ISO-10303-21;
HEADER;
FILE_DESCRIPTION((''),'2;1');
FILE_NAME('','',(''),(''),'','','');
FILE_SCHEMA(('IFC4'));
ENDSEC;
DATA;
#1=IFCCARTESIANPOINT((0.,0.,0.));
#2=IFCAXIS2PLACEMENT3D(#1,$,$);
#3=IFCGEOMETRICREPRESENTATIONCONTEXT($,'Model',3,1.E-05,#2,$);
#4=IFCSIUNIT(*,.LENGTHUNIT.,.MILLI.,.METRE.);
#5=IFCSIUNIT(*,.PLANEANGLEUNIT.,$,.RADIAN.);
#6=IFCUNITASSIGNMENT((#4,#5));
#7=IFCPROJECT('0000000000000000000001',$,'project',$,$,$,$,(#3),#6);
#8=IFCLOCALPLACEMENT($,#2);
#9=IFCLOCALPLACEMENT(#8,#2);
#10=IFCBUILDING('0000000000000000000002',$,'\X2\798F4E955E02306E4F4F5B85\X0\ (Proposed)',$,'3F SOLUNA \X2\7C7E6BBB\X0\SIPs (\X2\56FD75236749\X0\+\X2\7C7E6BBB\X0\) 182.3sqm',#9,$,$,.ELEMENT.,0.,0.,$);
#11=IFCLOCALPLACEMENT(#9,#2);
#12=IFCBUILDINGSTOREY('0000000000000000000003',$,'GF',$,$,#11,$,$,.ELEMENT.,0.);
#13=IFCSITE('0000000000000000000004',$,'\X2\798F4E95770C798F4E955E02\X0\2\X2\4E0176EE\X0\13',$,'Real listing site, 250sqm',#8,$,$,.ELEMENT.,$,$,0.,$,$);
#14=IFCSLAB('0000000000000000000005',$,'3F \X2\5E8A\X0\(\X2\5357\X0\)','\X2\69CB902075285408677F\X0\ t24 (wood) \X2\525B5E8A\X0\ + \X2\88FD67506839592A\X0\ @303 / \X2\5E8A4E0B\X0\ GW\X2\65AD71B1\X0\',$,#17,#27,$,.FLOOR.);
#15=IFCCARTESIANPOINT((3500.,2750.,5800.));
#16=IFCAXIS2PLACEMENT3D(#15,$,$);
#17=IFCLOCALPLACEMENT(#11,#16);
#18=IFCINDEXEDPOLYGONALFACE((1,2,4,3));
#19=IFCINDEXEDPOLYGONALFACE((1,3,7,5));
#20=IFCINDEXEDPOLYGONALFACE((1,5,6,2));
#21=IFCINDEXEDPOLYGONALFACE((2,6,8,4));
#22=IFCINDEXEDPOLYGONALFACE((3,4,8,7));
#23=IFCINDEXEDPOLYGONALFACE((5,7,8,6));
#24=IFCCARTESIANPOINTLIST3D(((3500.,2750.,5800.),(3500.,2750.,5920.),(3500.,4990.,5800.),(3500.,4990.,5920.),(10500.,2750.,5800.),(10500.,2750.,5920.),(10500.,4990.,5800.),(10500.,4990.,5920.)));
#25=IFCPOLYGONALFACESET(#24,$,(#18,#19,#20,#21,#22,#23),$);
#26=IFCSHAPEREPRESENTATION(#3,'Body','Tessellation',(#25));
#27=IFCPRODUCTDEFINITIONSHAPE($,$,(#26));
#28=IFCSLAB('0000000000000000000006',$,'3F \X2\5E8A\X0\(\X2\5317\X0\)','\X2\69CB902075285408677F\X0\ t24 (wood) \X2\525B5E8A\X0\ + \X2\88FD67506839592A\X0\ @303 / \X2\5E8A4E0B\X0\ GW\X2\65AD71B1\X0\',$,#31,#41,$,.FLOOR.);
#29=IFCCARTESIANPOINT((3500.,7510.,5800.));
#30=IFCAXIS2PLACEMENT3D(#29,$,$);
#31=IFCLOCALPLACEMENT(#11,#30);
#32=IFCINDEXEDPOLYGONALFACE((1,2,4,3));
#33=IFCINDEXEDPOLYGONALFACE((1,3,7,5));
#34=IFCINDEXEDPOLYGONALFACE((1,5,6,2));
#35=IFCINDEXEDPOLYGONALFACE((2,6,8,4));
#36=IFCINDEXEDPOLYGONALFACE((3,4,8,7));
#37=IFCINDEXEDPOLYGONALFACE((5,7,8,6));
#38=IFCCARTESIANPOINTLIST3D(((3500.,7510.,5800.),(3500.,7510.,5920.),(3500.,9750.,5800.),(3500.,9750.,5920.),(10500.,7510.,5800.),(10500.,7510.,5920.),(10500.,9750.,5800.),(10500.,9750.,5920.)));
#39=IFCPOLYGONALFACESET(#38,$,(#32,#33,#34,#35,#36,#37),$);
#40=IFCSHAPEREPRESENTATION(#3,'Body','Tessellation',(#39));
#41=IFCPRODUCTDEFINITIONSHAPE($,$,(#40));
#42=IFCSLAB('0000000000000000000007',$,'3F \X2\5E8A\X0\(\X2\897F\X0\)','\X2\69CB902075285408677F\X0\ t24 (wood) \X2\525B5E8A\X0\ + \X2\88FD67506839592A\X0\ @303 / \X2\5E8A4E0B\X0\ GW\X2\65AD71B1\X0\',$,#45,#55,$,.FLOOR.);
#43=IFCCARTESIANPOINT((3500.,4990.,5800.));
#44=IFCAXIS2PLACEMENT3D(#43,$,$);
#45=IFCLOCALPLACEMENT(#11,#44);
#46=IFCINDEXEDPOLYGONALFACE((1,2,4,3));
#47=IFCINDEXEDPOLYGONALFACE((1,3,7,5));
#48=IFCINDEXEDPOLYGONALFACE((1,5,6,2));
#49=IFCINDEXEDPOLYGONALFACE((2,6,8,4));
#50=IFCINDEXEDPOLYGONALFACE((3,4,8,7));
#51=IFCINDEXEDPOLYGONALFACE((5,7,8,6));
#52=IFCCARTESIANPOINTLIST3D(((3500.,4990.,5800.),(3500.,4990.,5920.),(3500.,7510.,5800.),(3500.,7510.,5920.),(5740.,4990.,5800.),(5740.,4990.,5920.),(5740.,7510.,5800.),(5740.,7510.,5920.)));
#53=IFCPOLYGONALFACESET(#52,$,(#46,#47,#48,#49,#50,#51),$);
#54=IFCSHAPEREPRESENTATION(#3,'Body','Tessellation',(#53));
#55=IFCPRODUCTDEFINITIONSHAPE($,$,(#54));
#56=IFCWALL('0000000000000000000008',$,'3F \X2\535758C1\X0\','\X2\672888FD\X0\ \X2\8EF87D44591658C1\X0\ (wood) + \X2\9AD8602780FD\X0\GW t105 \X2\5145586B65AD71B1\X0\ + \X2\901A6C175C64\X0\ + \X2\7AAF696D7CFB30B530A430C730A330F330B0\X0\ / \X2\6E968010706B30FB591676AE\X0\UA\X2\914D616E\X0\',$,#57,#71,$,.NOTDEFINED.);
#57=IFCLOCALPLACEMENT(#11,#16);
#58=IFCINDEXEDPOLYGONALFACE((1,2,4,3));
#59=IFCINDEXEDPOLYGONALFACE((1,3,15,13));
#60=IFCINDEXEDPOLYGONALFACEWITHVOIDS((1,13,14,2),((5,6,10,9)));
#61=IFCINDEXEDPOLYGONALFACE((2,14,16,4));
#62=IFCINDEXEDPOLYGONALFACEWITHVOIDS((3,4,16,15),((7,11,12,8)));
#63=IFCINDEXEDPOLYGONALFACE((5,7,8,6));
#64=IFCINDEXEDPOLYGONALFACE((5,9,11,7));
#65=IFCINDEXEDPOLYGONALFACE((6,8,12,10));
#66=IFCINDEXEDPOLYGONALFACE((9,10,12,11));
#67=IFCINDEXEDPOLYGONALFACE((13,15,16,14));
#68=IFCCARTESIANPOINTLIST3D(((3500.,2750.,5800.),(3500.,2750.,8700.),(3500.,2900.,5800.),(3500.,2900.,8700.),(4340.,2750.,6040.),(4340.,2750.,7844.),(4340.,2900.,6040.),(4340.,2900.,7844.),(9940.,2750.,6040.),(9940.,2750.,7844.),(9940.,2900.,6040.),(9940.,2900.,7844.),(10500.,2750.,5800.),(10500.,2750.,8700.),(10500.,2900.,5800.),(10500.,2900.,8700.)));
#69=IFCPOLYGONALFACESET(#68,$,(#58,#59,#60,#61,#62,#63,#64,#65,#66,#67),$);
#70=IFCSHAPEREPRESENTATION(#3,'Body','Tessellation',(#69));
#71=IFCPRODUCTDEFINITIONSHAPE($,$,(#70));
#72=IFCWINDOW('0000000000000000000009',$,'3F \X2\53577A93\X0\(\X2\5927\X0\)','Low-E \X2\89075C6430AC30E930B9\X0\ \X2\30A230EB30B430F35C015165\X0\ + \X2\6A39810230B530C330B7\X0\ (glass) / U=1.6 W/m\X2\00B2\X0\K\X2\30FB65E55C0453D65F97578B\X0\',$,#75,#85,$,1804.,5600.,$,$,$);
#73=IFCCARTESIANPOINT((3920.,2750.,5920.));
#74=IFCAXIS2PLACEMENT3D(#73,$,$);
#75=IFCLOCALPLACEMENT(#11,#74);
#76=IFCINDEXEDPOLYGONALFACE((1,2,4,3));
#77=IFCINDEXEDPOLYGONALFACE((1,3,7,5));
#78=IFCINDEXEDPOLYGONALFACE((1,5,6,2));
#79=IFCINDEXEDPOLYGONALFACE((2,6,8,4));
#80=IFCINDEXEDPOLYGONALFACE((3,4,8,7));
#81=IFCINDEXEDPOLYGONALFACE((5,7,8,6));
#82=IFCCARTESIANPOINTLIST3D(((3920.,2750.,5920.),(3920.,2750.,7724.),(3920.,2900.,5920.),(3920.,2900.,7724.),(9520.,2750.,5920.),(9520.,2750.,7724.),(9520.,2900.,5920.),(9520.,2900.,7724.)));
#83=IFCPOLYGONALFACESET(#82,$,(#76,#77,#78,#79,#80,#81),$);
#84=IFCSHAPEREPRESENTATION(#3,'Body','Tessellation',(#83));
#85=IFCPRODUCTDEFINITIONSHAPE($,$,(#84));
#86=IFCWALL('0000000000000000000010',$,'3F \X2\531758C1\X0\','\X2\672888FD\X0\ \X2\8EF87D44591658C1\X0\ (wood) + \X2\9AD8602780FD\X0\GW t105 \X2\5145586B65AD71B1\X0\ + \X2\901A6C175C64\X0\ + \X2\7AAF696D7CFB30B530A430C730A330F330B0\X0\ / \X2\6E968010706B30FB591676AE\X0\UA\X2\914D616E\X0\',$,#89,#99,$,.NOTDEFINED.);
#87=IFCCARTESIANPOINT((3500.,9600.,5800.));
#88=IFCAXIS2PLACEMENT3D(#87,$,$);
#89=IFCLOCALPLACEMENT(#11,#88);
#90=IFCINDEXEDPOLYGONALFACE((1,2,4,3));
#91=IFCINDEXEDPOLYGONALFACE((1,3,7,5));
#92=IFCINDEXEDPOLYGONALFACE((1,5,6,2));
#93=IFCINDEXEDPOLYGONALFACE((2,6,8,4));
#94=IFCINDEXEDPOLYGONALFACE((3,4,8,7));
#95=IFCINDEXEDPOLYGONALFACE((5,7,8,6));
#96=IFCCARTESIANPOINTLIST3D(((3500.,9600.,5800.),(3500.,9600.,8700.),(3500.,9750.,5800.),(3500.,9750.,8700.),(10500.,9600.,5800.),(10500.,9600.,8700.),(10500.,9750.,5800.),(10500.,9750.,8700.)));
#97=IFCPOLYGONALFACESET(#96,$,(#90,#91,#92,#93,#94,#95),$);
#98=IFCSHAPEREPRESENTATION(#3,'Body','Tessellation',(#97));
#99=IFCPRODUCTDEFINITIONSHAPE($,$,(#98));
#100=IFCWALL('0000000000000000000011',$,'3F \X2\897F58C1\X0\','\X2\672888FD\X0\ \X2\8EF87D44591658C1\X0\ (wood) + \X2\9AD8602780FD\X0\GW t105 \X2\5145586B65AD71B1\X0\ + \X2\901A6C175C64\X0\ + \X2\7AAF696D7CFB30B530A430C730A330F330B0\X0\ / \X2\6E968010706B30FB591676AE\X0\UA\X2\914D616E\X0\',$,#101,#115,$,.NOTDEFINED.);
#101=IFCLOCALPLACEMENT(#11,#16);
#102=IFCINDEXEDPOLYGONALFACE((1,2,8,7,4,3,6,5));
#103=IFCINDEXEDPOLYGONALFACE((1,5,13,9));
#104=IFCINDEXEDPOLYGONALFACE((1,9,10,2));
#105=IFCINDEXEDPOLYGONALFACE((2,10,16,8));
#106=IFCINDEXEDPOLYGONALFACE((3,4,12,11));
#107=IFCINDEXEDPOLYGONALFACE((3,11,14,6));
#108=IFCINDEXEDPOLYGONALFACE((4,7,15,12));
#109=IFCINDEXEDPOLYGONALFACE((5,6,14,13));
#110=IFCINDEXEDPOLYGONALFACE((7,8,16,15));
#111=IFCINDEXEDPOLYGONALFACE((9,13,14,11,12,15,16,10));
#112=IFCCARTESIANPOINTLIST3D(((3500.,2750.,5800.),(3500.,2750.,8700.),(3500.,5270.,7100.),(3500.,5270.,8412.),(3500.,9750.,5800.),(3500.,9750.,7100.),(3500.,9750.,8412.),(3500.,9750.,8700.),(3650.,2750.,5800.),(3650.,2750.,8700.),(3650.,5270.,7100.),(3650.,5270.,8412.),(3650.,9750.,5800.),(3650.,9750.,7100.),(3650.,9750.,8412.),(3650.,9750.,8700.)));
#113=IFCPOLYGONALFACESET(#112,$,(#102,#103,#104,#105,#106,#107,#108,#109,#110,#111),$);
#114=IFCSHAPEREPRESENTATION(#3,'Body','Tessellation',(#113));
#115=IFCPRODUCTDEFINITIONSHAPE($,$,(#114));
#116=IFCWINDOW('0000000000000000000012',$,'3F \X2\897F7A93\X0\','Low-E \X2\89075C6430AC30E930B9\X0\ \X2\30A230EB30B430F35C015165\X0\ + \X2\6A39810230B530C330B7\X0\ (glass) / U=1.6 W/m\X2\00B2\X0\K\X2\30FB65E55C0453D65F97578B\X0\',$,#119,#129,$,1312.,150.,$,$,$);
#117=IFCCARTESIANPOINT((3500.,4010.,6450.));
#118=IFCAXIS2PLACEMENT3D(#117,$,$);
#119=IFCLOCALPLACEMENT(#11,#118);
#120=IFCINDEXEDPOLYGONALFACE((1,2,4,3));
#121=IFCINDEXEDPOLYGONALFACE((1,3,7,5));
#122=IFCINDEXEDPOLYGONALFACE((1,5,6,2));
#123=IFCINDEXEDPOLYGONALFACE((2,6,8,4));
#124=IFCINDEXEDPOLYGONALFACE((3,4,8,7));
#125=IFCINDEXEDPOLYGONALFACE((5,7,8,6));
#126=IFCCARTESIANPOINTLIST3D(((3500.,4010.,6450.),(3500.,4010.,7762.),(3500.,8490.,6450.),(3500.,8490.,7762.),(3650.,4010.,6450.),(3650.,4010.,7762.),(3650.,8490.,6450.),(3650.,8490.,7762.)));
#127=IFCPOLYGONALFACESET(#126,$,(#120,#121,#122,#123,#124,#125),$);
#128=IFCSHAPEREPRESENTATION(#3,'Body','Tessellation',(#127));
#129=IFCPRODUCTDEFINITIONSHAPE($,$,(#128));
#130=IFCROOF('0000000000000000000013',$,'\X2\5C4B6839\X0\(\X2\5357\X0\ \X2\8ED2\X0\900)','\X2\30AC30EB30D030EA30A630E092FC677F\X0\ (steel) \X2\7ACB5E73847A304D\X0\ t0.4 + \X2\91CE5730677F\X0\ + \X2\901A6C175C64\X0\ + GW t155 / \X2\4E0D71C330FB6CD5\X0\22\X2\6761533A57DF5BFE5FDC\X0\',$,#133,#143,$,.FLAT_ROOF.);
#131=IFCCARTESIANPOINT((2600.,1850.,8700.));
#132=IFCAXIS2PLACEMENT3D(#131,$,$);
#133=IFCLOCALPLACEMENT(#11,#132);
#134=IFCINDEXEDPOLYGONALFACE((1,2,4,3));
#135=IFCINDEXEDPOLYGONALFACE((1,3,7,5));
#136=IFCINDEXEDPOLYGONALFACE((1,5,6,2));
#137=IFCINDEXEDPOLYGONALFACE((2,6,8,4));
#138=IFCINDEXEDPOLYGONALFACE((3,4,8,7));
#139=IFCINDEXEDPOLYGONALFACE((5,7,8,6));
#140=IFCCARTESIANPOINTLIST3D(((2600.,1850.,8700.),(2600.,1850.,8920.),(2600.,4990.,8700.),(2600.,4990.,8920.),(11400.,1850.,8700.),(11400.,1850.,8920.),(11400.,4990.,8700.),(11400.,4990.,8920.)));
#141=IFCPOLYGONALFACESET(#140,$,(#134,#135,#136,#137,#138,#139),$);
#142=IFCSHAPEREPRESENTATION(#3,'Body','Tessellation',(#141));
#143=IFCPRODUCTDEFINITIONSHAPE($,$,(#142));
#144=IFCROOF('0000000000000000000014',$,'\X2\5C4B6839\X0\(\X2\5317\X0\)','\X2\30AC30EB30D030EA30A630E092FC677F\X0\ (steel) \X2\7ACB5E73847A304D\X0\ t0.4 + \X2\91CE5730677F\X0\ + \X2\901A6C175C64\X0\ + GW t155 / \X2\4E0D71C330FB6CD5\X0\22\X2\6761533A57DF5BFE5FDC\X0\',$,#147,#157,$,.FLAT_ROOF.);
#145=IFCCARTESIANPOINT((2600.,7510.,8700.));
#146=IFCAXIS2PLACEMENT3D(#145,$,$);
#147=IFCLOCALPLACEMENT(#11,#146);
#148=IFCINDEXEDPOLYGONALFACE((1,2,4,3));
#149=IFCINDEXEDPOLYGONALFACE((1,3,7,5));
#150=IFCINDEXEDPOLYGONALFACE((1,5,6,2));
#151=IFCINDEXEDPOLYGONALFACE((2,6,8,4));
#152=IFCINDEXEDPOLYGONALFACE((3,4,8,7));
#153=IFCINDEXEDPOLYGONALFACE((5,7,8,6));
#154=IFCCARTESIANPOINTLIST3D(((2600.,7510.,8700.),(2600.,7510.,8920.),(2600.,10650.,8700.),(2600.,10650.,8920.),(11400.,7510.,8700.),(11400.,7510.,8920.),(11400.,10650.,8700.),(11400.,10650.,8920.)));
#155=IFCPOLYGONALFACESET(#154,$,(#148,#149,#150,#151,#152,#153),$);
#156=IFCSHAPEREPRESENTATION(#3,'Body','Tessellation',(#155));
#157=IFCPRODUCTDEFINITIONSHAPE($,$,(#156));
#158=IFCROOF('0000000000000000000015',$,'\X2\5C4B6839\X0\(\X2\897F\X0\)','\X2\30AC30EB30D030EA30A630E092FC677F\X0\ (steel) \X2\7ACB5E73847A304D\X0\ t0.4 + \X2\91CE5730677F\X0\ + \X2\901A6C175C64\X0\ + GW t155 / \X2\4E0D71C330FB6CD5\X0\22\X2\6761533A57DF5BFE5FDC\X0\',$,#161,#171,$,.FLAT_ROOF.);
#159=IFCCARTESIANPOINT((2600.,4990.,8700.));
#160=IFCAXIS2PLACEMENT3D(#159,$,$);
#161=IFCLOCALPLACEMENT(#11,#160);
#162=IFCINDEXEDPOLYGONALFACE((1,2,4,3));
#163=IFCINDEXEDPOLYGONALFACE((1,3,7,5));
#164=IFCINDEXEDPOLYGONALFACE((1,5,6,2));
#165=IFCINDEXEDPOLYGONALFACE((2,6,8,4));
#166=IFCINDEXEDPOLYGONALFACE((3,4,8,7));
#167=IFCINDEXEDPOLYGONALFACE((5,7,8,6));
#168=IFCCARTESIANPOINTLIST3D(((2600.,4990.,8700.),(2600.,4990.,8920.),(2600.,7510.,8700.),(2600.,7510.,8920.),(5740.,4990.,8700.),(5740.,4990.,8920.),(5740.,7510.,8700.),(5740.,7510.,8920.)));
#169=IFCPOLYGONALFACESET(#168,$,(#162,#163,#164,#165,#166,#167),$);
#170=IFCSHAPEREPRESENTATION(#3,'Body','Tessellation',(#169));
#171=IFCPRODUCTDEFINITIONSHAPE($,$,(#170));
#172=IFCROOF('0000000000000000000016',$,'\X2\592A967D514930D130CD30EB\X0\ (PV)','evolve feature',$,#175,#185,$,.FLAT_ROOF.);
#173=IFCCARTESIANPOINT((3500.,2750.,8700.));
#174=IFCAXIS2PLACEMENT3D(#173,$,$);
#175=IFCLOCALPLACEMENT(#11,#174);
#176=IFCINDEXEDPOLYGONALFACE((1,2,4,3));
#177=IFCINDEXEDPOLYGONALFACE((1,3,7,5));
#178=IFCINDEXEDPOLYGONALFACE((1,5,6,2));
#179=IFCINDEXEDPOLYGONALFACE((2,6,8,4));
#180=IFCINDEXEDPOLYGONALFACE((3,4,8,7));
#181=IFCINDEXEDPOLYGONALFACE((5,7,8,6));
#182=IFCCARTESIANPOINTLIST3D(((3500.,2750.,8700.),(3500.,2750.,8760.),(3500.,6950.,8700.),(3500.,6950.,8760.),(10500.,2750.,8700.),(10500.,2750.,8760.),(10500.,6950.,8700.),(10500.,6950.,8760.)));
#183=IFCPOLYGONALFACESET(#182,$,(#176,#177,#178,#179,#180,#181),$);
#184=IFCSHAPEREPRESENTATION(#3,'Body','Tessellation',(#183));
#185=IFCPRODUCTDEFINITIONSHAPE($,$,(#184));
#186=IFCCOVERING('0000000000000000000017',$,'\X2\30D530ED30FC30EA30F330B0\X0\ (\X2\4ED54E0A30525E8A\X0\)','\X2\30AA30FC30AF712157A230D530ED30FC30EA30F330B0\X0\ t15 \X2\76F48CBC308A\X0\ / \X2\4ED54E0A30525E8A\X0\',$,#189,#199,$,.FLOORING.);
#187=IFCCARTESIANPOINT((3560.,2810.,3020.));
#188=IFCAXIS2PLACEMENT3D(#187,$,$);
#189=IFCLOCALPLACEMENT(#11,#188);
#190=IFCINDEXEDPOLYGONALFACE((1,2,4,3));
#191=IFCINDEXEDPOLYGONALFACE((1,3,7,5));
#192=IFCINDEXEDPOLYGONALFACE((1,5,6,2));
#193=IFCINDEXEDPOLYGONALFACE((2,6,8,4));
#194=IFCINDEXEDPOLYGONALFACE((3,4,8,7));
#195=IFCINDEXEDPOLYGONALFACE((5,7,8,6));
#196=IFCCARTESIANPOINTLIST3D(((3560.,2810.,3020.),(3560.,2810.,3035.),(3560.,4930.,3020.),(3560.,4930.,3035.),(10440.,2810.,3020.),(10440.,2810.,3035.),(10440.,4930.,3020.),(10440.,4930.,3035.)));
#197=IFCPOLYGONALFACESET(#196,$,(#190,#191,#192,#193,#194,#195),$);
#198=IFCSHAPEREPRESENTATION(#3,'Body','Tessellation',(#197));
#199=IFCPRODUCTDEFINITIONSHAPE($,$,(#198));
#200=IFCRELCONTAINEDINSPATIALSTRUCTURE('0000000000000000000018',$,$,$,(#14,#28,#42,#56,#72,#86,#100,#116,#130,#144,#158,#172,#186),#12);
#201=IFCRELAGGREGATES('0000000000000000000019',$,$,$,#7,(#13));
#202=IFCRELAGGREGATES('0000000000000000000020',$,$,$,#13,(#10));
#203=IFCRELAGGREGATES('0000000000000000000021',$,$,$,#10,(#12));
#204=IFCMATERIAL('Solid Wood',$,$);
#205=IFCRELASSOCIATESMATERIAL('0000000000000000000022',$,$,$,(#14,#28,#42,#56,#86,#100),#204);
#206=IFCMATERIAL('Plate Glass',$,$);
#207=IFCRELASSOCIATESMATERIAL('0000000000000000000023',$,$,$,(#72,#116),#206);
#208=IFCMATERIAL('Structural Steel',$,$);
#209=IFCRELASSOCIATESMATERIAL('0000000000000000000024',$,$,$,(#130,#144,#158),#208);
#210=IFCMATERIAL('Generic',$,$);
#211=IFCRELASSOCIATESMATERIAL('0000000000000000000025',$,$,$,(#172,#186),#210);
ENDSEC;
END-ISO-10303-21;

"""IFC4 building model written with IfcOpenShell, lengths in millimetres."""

from ifc_helpers import new_model, si_unit, frame, frame_2d, origin, place, context, project, spatial, rectangle, extrude, material, element, fill, save


model = new_model("IFC4")

# Units and contexts
model_context = context("Model", 3, precision=1e-05, world=origin())
ifc_project = project(units=[si_unit("LENGTHUNIT", "METRE", prefix="MILLI"), si_unit("PLANEANGLEUNIT", "RADIAN")], contexts=[model_context])

# Site, building, storey
site_placement = place(None, origin())
site = spatial("IfcSite", under=ifc_project, at=site_placement, Name="福井県福井市2丁目13", ObjectType="Real listing site, 250sqm", CompositionType="ELEMENT", RefElevation=0.0)
building_placement = place(site_placement, origin())
building = spatial("IfcBuilding", under=site, at=building_placement, Name="福井市の住宅 (Proposed)", ObjectType="3F SOLUNA 籾殻SIPs (国産杉+籾殻) 182.3sqm", CompositionType="ELEMENT", ElevationOfRefHeight=0.0, ElevationOfTerrain=0.0)
storey_placement = place(building_placement, origin())
storey = spatial("IfcBuildingStorey", under=building, at=storey_placement, Name="GF", CompositionType="ELEMENT", Elevation=0.0)

# Slabs
ifc_material_1 = material(Name="Solid Wood")
slab_1_placement = place(storey_placement, frame((3500.0, 2750.0, 5800.0)))
element("IfcSlab", 1, at=slab_1_placement, inside=storey, material=ifc_material_1, Name="3F 床(南)", Description="構造用合板 t24 (wood) 剛床 + 製材根太 @303 / 床下 GW断熱", PredefinedType="FLOOR", context=model_context, shape_type="SweptSolid", body=[
    extrude(rectangle(XDim=7000.0, YDim=2240.0, at=frame_2d((3500.0, 1120.0))), frame((3500.0, 2750.0, 5800.0)), (0.0, 0.0, 1.0), 120.0),
])
slab_2_placement = place(storey_placement, frame((3500.0, 7510.0, 5800.0)))
element("IfcSlab", 2, at=slab_2_placement, inside=storey, material=ifc_material_1, Name="3F 床(北)", Description="構造用合板 t24 (wood) 剛床 + 製材根太 @303 / 床下 GW断熱", PredefinedType="FLOOR", context=model_context, shape_type="SweptSolid", body=[
    extrude(rectangle(XDim=7000.0, YDim=2240.0, at=frame_2d((3500.0, 1120.0))), frame((3500.0, 7510.0, 5800.0)), (0.0, 0.0, 1.0), 120.0),
])
slab_3_placement = place(storey_placement, frame((3500.0, 4990.0, 5800.0)))
element("IfcSlab", 3, at=slab_3_placement, inside=storey, material=ifc_material_1, Name="3F 床(西)", Description="構造用合板 t24 (wood) 剛床 + 製材根太 @303 / 床下 GW断熱", PredefinedType="FLOOR", context=model_context, shape_type="SweptSolid", body=[
    extrude(rectangle(XDim=2240.0, YDim=2520.0, at=frame_2d((1120.0, 1260.0))), frame((3500.0, 4990.0, 5800.0)), (0.0, 0.0, 1.0), 120.0),
])

# Wall, opening, window
wall_1_placement = place(storey_placement, frame((3500.0, 2750.0, 5800.0)))
wall_1 = element("IfcWall", 4, at=wall_1_placement, inside=storey, material=ifc_material_1, Name="3F 南壁", Description="木製 軸組外壁 (wood) + 高性能GW t105 充填断熱 + 通気層 + 窯業系サイディング / 準耐火・外皮UA配慮", PredefinedType="NOTDEFINED", context=model_context, shape_type="SweptSolid", body=[
    extrude(rectangle(XDim=7000.0, YDim=150.0, at=frame_2d((3500.0, 75.0))), frame((3500.0, 2750.0, 5800.0)), (0.0, 0.0, 1.0), 2900.0),
])
opening_1_placement = place(storey_placement, frame((3920.0, 2750.0, 5920.0)))
opening_1 = element("IfcOpeningElement", 5, at=opening_1_placement, cuts=wall_1, PredefinedType="NOTDEFINED", context=model_context, shape_type="SweptSolid", body=[
    extrude(rectangle(XDim=5600.0, YDim=150.0, at=frame_2d((2800.0, 75.0))), frame((3920.0, 2750.0, 5920.0)), (0.0, 0.0, 1.0), 1804.0),
])
ifc_material_2 = material(Name="Plate Glass")
window_1_placement = place(storey_placement, frame((3920.0, 2750.0, 5920.0)))
window_1 = element("IfcWindow", 6, at=window_1_placement, inside=storey, material=ifc_material_2, Name="3F 南窓(大)", Description="Low-E 複層ガラス アルゴン封入 + 樹脂サッシ (glass) / U=1.6 W/m²K・日射取得型", OverallHeight=1804.0, OverallWidth=5600.0, context=model_context, shape_type="SweptSolid", body=[
    extrude(rectangle(XDim=5600.0, YDim=150.0, at=frame_2d((2800.0, 75.0))), frame((3920.0, 2750.0, 5920.0)), (0.0, 0.0, 1.0), 1804.0),
])
fill(opening_1, window_1)

# Wall
wall_2_placement = place(storey_placement, frame((3500.0, 9600.0, 5800.0)))
element("IfcWall", 7, at=wall_2_placement, inside=storey, material=ifc_material_1, Name="3F 北壁", Description="木製 軸組外壁 (wood) + 高性能GW t105 充填断熱 + 通気層 + 窯業系サイディング / 準耐火・外皮UA配慮", PredefinedType="NOTDEFINED", context=model_context, shape_type="SweptSolid", body=[
    extrude(rectangle(XDim=7000.0, YDim=150.0, at=frame_2d((3500.0, 75.0))), frame((3500.0, 9600.0, 5800.0)), (0.0, 0.0, 1.0), 2900.0),
])

# Wall, opening, window
wall_3_placement = place(storey_placement, frame((3500.0, 2750.0, 5800.0)))
wall_3 = element("IfcWall", 8, at=wall_3_placement, inside=storey, material=ifc_material_1, Name="3F 西壁", Description="木製 軸組外壁 (wood) + 高性能GW t105 充填断熱 + 通気層 + 窯業系サイディング / 準耐火・外皮UA配慮", PredefinedType="NOTDEFINED", context=model_context, shape_type="SweptSolid", body=[
    extrude(rectangle(XDim=150.0, YDim=7000.0, at=frame_2d((75.0, 3500.0))), frame((3500.0, 2750.0, 5800.0)), (0.0, 0.0, 1.0), 2900.0),
])
opening_2_placement = place(storey_placement, frame((3500.0, 4010.0, 6450.0)))
opening_2 = element("IfcOpeningElement", 9, at=opening_2_placement, cuts=wall_3, PredefinedType="NOTDEFINED", context=model_context, shape_type="SweptSolid", body=[
    extrude(rectangle(XDim=150.0, YDim=4480.0, at=frame_2d((75.0, 2240.0))), frame((3500.0, 4010.0, 6450.0)), (0.0, 0.0, 1.0), 1312.0),
])
window_2_placement = place(storey_placement, frame((3500.0, 4010.0, 6450.0)))
window_2 = element("IfcWindow", 10, at=window_2_placement, inside=storey, material=ifc_material_2, Name="3F 西窓", Description="Low-E 複層ガラス アルゴン封入 + 樹脂サッシ (glass) / U=1.6 W/m²K・日射取得型", OverallHeight=1312.0, OverallWidth=150.0, context=model_context, shape_type="SweptSolid", body=[
    extrude(rectangle(XDim=150.0, YDim=4480.0, at=frame_2d((75.0, 2240.0))), frame((3500.0, 4010.0, 6450.0)), (0.0, 0.0, 1.0), 1312.0),
])
fill(opening_2, window_2)

# Roofs
ifc_material_3 = material(Name="Structural Steel")
roof_1_placement = place(storey_placement, frame((2600.0, 1850.0, 8700.0)))
element("IfcRoof", 11, at=roof_1_placement, inside=storey, material=ifc_material_3, Name="屋根(南 軒900)", Description="ガルバリウム鋼板 (steel) 立平葺き t0.4 + 野地板 + 通気層 + GW t155 / 不燃・法22条区域対応", PredefinedType="FLAT_ROOF", context=model_context, shape_type="SweptSolid", body=[
    extrude(rectangle(XDim=8800.0, YDim=3140.0, at=frame_2d((4400.0, 1570.0))), frame((2600.0, 1850.0, 8700.0)), (0.0, 0.0, 1.0), 220.0),
])
roof_2_placement = place(storey_placement, frame((2600.0, 7510.0, 8700.0)))
element("IfcRoof", 12, at=roof_2_placement, inside=storey, material=ifc_material_3, Name="屋根(北)", Description="ガルバリウム鋼板 (steel) 立平葺き t0.4 + 野地板 + 通気層 + GW t155 / 不燃・法22条区域対応", PredefinedType="FLAT_ROOF", context=model_context, shape_type="SweptSolid", body=[
    extrude(rectangle(XDim=8800.0, YDim=3140.0, at=frame_2d((4400.0, 1570.0))), frame((2600.0, 7510.0, 8700.0)), (0.0, 0.0, 1.0), 220.0),
])
roof_3_placement = place(storey_placement, frame((2600.0, 4990.0, 8700.0)))
element("IfcRoof", 13, at=roof_3_placement, inside=storey, material=ifc_material_3, Name="屋根(西)", Description="ガルバリウム鋼板 (steel) 立平葺き t0.4 + 野地板 + 通気層 + GW t155 / 不燃・法22条区域対応", PredefinedType="FLAT_ROOF", context=model_context, shape_type="SweptSolid", body=[
    extrude(rectangle(XDim=3140.0, YDim=2520.0, at=frame_2d((1570.0, 1260.0))), frame((2600.0, 4990.0, 8700.0)), (0.0, 0.0, 1.0), 220.0),
])
ifc_material_4 = material(Name="Generic")
roof_4_placement = place(storey_placement, frame((3500.0, 2750.0, 8700.0)))
element("IfcRoof", 14, at=roof_4_placement, inside=storey, material=ifc_material_4, Name="太陽光パネル (PV)", Description="evolve feature", PredefinedType="FLAT_ROOF", context=model_context, shape_type="SweptSolid", body=[
    extrude(rectangle(XDim=7000.0, YDim=4200.0, at=frame_2d((3500.0, 2100.0))), frame((3500.0, 2750.0, 8700.0)), (0.0, 0.0, 1.0), 60.0),
])

# Covering
covering_1_placement = place(storey_placement, frame((3560.0, 2810.0, 3020.0)))
element("IfcCovering", 15, at=covering_1_placement, inside=storey, material=ifc_material_4, Name="フローリング (仕上げ床)", Description="オーク無垢フローリング t15 直貼り / 仕上げ床", PredefinedType="FLOORING", context=model_context, shape_type="SweptSolid", body=[
    extrude(rectangle(XDim=6880.0, YDim=2120.0, at=frame_2d((3440.0, 1060.0))), frame((3560.0, 2810.0, 3020.0)), (0.0, 0.0, 1.0), 15.0),
])

save(model, "model.ifc")
